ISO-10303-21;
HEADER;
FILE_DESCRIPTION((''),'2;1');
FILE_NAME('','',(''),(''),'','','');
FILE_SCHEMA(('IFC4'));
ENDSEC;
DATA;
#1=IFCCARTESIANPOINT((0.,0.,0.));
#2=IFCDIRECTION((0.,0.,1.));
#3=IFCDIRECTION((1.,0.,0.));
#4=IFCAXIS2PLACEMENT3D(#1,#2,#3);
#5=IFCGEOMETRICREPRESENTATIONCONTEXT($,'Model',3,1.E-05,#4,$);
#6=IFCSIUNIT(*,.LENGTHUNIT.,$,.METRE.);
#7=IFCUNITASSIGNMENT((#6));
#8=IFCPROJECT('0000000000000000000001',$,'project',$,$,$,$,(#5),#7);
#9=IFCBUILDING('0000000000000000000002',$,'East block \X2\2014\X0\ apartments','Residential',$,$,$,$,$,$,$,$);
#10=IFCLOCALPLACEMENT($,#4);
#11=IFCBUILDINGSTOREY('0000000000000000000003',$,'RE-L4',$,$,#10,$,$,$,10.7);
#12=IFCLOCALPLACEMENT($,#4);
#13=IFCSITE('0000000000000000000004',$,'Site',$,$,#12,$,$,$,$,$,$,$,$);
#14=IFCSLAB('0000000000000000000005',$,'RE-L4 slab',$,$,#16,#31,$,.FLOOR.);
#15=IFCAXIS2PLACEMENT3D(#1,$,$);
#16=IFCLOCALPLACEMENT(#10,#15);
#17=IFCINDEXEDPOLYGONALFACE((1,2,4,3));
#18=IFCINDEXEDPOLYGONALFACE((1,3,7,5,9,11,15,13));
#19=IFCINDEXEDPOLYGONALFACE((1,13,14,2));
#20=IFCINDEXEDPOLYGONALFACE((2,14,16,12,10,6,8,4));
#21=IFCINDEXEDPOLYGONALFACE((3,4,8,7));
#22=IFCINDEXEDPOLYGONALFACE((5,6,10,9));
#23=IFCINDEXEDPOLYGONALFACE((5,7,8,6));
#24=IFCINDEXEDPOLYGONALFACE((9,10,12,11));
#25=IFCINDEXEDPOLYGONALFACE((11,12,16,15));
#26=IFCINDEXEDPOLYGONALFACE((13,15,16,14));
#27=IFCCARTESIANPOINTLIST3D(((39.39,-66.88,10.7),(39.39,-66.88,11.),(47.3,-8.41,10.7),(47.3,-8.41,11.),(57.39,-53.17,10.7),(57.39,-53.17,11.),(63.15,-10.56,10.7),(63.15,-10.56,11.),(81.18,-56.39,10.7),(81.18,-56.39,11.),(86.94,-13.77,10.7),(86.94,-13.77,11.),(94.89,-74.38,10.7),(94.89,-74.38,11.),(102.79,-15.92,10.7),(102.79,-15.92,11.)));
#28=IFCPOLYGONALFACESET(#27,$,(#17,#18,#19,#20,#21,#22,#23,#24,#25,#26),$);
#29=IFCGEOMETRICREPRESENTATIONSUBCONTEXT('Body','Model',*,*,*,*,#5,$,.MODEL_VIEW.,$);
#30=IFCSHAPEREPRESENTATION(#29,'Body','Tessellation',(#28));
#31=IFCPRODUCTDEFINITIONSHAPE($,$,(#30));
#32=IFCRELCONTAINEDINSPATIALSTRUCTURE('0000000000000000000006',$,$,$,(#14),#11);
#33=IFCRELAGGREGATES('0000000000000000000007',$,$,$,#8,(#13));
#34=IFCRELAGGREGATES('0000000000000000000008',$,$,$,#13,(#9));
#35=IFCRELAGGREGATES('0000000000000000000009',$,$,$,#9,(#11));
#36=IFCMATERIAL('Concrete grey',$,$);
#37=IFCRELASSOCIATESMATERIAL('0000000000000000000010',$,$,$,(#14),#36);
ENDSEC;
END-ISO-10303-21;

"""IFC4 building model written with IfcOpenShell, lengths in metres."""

from ifc_helpers import new_model, si_unit, frame, origin_with_axes, place, context, subcontext, project, spatial, polyline, outline, extrude, material, element, save


model = new_model("IFC4")

# Units and contexts
model_context = context("Model", 3, precision=1e-05, world=origin_with_axes())
body_context = subcontext(model_context, "Body", "Model", "MODEL_VIEW")
ifc_project = project(units=[si_unit("LENGTHUNIT", "METRE")], contexts=[model_context])

# Site, building, storey
site_placement = place(None, origin_with_axes())
site = spatial("IfcSite", under=ifc_project, at=site_placement, Name="Site")
building = spatial("IfcBuilding", under=site, Name="East block — apartments", Description="Residential")
storey_placement = place(None, origin_with_axes())
storey = spatial("IfcBuildingStorey", under=building, at=storey_placement, Name="RE-L4", Elevation=10.7)

# Slab
ifc_material = material(Name="Concrete grey")
slab_placement = place(storey_placement, origin_with_axes())
element("IfcSlab", 1, at=slab_placement, inside=storey, material=ifc_material, Name="RE-L4 slab", PredefinedType="FLOOR", context=body_context, shape_type="SweptSolid", body=[
    extrude(outline(polyline([(39.39, -66.88), (94.89, -74.38), (102.79, -15.92), (86.94, -13.77), (81.18, -56.39), (57.39, -53.17), (63.15, -10.56), (47.3, -8.41), (39.39, -66.88)])), frame((0.0, 0.0, 10.7), z_axis=(0.0, 0.0, 1.0), x_axis=(1.0, 0.0, 0.0)), (0.0, 0.0, 1.0), 0.3),
])

save(model, "model.ifc")
